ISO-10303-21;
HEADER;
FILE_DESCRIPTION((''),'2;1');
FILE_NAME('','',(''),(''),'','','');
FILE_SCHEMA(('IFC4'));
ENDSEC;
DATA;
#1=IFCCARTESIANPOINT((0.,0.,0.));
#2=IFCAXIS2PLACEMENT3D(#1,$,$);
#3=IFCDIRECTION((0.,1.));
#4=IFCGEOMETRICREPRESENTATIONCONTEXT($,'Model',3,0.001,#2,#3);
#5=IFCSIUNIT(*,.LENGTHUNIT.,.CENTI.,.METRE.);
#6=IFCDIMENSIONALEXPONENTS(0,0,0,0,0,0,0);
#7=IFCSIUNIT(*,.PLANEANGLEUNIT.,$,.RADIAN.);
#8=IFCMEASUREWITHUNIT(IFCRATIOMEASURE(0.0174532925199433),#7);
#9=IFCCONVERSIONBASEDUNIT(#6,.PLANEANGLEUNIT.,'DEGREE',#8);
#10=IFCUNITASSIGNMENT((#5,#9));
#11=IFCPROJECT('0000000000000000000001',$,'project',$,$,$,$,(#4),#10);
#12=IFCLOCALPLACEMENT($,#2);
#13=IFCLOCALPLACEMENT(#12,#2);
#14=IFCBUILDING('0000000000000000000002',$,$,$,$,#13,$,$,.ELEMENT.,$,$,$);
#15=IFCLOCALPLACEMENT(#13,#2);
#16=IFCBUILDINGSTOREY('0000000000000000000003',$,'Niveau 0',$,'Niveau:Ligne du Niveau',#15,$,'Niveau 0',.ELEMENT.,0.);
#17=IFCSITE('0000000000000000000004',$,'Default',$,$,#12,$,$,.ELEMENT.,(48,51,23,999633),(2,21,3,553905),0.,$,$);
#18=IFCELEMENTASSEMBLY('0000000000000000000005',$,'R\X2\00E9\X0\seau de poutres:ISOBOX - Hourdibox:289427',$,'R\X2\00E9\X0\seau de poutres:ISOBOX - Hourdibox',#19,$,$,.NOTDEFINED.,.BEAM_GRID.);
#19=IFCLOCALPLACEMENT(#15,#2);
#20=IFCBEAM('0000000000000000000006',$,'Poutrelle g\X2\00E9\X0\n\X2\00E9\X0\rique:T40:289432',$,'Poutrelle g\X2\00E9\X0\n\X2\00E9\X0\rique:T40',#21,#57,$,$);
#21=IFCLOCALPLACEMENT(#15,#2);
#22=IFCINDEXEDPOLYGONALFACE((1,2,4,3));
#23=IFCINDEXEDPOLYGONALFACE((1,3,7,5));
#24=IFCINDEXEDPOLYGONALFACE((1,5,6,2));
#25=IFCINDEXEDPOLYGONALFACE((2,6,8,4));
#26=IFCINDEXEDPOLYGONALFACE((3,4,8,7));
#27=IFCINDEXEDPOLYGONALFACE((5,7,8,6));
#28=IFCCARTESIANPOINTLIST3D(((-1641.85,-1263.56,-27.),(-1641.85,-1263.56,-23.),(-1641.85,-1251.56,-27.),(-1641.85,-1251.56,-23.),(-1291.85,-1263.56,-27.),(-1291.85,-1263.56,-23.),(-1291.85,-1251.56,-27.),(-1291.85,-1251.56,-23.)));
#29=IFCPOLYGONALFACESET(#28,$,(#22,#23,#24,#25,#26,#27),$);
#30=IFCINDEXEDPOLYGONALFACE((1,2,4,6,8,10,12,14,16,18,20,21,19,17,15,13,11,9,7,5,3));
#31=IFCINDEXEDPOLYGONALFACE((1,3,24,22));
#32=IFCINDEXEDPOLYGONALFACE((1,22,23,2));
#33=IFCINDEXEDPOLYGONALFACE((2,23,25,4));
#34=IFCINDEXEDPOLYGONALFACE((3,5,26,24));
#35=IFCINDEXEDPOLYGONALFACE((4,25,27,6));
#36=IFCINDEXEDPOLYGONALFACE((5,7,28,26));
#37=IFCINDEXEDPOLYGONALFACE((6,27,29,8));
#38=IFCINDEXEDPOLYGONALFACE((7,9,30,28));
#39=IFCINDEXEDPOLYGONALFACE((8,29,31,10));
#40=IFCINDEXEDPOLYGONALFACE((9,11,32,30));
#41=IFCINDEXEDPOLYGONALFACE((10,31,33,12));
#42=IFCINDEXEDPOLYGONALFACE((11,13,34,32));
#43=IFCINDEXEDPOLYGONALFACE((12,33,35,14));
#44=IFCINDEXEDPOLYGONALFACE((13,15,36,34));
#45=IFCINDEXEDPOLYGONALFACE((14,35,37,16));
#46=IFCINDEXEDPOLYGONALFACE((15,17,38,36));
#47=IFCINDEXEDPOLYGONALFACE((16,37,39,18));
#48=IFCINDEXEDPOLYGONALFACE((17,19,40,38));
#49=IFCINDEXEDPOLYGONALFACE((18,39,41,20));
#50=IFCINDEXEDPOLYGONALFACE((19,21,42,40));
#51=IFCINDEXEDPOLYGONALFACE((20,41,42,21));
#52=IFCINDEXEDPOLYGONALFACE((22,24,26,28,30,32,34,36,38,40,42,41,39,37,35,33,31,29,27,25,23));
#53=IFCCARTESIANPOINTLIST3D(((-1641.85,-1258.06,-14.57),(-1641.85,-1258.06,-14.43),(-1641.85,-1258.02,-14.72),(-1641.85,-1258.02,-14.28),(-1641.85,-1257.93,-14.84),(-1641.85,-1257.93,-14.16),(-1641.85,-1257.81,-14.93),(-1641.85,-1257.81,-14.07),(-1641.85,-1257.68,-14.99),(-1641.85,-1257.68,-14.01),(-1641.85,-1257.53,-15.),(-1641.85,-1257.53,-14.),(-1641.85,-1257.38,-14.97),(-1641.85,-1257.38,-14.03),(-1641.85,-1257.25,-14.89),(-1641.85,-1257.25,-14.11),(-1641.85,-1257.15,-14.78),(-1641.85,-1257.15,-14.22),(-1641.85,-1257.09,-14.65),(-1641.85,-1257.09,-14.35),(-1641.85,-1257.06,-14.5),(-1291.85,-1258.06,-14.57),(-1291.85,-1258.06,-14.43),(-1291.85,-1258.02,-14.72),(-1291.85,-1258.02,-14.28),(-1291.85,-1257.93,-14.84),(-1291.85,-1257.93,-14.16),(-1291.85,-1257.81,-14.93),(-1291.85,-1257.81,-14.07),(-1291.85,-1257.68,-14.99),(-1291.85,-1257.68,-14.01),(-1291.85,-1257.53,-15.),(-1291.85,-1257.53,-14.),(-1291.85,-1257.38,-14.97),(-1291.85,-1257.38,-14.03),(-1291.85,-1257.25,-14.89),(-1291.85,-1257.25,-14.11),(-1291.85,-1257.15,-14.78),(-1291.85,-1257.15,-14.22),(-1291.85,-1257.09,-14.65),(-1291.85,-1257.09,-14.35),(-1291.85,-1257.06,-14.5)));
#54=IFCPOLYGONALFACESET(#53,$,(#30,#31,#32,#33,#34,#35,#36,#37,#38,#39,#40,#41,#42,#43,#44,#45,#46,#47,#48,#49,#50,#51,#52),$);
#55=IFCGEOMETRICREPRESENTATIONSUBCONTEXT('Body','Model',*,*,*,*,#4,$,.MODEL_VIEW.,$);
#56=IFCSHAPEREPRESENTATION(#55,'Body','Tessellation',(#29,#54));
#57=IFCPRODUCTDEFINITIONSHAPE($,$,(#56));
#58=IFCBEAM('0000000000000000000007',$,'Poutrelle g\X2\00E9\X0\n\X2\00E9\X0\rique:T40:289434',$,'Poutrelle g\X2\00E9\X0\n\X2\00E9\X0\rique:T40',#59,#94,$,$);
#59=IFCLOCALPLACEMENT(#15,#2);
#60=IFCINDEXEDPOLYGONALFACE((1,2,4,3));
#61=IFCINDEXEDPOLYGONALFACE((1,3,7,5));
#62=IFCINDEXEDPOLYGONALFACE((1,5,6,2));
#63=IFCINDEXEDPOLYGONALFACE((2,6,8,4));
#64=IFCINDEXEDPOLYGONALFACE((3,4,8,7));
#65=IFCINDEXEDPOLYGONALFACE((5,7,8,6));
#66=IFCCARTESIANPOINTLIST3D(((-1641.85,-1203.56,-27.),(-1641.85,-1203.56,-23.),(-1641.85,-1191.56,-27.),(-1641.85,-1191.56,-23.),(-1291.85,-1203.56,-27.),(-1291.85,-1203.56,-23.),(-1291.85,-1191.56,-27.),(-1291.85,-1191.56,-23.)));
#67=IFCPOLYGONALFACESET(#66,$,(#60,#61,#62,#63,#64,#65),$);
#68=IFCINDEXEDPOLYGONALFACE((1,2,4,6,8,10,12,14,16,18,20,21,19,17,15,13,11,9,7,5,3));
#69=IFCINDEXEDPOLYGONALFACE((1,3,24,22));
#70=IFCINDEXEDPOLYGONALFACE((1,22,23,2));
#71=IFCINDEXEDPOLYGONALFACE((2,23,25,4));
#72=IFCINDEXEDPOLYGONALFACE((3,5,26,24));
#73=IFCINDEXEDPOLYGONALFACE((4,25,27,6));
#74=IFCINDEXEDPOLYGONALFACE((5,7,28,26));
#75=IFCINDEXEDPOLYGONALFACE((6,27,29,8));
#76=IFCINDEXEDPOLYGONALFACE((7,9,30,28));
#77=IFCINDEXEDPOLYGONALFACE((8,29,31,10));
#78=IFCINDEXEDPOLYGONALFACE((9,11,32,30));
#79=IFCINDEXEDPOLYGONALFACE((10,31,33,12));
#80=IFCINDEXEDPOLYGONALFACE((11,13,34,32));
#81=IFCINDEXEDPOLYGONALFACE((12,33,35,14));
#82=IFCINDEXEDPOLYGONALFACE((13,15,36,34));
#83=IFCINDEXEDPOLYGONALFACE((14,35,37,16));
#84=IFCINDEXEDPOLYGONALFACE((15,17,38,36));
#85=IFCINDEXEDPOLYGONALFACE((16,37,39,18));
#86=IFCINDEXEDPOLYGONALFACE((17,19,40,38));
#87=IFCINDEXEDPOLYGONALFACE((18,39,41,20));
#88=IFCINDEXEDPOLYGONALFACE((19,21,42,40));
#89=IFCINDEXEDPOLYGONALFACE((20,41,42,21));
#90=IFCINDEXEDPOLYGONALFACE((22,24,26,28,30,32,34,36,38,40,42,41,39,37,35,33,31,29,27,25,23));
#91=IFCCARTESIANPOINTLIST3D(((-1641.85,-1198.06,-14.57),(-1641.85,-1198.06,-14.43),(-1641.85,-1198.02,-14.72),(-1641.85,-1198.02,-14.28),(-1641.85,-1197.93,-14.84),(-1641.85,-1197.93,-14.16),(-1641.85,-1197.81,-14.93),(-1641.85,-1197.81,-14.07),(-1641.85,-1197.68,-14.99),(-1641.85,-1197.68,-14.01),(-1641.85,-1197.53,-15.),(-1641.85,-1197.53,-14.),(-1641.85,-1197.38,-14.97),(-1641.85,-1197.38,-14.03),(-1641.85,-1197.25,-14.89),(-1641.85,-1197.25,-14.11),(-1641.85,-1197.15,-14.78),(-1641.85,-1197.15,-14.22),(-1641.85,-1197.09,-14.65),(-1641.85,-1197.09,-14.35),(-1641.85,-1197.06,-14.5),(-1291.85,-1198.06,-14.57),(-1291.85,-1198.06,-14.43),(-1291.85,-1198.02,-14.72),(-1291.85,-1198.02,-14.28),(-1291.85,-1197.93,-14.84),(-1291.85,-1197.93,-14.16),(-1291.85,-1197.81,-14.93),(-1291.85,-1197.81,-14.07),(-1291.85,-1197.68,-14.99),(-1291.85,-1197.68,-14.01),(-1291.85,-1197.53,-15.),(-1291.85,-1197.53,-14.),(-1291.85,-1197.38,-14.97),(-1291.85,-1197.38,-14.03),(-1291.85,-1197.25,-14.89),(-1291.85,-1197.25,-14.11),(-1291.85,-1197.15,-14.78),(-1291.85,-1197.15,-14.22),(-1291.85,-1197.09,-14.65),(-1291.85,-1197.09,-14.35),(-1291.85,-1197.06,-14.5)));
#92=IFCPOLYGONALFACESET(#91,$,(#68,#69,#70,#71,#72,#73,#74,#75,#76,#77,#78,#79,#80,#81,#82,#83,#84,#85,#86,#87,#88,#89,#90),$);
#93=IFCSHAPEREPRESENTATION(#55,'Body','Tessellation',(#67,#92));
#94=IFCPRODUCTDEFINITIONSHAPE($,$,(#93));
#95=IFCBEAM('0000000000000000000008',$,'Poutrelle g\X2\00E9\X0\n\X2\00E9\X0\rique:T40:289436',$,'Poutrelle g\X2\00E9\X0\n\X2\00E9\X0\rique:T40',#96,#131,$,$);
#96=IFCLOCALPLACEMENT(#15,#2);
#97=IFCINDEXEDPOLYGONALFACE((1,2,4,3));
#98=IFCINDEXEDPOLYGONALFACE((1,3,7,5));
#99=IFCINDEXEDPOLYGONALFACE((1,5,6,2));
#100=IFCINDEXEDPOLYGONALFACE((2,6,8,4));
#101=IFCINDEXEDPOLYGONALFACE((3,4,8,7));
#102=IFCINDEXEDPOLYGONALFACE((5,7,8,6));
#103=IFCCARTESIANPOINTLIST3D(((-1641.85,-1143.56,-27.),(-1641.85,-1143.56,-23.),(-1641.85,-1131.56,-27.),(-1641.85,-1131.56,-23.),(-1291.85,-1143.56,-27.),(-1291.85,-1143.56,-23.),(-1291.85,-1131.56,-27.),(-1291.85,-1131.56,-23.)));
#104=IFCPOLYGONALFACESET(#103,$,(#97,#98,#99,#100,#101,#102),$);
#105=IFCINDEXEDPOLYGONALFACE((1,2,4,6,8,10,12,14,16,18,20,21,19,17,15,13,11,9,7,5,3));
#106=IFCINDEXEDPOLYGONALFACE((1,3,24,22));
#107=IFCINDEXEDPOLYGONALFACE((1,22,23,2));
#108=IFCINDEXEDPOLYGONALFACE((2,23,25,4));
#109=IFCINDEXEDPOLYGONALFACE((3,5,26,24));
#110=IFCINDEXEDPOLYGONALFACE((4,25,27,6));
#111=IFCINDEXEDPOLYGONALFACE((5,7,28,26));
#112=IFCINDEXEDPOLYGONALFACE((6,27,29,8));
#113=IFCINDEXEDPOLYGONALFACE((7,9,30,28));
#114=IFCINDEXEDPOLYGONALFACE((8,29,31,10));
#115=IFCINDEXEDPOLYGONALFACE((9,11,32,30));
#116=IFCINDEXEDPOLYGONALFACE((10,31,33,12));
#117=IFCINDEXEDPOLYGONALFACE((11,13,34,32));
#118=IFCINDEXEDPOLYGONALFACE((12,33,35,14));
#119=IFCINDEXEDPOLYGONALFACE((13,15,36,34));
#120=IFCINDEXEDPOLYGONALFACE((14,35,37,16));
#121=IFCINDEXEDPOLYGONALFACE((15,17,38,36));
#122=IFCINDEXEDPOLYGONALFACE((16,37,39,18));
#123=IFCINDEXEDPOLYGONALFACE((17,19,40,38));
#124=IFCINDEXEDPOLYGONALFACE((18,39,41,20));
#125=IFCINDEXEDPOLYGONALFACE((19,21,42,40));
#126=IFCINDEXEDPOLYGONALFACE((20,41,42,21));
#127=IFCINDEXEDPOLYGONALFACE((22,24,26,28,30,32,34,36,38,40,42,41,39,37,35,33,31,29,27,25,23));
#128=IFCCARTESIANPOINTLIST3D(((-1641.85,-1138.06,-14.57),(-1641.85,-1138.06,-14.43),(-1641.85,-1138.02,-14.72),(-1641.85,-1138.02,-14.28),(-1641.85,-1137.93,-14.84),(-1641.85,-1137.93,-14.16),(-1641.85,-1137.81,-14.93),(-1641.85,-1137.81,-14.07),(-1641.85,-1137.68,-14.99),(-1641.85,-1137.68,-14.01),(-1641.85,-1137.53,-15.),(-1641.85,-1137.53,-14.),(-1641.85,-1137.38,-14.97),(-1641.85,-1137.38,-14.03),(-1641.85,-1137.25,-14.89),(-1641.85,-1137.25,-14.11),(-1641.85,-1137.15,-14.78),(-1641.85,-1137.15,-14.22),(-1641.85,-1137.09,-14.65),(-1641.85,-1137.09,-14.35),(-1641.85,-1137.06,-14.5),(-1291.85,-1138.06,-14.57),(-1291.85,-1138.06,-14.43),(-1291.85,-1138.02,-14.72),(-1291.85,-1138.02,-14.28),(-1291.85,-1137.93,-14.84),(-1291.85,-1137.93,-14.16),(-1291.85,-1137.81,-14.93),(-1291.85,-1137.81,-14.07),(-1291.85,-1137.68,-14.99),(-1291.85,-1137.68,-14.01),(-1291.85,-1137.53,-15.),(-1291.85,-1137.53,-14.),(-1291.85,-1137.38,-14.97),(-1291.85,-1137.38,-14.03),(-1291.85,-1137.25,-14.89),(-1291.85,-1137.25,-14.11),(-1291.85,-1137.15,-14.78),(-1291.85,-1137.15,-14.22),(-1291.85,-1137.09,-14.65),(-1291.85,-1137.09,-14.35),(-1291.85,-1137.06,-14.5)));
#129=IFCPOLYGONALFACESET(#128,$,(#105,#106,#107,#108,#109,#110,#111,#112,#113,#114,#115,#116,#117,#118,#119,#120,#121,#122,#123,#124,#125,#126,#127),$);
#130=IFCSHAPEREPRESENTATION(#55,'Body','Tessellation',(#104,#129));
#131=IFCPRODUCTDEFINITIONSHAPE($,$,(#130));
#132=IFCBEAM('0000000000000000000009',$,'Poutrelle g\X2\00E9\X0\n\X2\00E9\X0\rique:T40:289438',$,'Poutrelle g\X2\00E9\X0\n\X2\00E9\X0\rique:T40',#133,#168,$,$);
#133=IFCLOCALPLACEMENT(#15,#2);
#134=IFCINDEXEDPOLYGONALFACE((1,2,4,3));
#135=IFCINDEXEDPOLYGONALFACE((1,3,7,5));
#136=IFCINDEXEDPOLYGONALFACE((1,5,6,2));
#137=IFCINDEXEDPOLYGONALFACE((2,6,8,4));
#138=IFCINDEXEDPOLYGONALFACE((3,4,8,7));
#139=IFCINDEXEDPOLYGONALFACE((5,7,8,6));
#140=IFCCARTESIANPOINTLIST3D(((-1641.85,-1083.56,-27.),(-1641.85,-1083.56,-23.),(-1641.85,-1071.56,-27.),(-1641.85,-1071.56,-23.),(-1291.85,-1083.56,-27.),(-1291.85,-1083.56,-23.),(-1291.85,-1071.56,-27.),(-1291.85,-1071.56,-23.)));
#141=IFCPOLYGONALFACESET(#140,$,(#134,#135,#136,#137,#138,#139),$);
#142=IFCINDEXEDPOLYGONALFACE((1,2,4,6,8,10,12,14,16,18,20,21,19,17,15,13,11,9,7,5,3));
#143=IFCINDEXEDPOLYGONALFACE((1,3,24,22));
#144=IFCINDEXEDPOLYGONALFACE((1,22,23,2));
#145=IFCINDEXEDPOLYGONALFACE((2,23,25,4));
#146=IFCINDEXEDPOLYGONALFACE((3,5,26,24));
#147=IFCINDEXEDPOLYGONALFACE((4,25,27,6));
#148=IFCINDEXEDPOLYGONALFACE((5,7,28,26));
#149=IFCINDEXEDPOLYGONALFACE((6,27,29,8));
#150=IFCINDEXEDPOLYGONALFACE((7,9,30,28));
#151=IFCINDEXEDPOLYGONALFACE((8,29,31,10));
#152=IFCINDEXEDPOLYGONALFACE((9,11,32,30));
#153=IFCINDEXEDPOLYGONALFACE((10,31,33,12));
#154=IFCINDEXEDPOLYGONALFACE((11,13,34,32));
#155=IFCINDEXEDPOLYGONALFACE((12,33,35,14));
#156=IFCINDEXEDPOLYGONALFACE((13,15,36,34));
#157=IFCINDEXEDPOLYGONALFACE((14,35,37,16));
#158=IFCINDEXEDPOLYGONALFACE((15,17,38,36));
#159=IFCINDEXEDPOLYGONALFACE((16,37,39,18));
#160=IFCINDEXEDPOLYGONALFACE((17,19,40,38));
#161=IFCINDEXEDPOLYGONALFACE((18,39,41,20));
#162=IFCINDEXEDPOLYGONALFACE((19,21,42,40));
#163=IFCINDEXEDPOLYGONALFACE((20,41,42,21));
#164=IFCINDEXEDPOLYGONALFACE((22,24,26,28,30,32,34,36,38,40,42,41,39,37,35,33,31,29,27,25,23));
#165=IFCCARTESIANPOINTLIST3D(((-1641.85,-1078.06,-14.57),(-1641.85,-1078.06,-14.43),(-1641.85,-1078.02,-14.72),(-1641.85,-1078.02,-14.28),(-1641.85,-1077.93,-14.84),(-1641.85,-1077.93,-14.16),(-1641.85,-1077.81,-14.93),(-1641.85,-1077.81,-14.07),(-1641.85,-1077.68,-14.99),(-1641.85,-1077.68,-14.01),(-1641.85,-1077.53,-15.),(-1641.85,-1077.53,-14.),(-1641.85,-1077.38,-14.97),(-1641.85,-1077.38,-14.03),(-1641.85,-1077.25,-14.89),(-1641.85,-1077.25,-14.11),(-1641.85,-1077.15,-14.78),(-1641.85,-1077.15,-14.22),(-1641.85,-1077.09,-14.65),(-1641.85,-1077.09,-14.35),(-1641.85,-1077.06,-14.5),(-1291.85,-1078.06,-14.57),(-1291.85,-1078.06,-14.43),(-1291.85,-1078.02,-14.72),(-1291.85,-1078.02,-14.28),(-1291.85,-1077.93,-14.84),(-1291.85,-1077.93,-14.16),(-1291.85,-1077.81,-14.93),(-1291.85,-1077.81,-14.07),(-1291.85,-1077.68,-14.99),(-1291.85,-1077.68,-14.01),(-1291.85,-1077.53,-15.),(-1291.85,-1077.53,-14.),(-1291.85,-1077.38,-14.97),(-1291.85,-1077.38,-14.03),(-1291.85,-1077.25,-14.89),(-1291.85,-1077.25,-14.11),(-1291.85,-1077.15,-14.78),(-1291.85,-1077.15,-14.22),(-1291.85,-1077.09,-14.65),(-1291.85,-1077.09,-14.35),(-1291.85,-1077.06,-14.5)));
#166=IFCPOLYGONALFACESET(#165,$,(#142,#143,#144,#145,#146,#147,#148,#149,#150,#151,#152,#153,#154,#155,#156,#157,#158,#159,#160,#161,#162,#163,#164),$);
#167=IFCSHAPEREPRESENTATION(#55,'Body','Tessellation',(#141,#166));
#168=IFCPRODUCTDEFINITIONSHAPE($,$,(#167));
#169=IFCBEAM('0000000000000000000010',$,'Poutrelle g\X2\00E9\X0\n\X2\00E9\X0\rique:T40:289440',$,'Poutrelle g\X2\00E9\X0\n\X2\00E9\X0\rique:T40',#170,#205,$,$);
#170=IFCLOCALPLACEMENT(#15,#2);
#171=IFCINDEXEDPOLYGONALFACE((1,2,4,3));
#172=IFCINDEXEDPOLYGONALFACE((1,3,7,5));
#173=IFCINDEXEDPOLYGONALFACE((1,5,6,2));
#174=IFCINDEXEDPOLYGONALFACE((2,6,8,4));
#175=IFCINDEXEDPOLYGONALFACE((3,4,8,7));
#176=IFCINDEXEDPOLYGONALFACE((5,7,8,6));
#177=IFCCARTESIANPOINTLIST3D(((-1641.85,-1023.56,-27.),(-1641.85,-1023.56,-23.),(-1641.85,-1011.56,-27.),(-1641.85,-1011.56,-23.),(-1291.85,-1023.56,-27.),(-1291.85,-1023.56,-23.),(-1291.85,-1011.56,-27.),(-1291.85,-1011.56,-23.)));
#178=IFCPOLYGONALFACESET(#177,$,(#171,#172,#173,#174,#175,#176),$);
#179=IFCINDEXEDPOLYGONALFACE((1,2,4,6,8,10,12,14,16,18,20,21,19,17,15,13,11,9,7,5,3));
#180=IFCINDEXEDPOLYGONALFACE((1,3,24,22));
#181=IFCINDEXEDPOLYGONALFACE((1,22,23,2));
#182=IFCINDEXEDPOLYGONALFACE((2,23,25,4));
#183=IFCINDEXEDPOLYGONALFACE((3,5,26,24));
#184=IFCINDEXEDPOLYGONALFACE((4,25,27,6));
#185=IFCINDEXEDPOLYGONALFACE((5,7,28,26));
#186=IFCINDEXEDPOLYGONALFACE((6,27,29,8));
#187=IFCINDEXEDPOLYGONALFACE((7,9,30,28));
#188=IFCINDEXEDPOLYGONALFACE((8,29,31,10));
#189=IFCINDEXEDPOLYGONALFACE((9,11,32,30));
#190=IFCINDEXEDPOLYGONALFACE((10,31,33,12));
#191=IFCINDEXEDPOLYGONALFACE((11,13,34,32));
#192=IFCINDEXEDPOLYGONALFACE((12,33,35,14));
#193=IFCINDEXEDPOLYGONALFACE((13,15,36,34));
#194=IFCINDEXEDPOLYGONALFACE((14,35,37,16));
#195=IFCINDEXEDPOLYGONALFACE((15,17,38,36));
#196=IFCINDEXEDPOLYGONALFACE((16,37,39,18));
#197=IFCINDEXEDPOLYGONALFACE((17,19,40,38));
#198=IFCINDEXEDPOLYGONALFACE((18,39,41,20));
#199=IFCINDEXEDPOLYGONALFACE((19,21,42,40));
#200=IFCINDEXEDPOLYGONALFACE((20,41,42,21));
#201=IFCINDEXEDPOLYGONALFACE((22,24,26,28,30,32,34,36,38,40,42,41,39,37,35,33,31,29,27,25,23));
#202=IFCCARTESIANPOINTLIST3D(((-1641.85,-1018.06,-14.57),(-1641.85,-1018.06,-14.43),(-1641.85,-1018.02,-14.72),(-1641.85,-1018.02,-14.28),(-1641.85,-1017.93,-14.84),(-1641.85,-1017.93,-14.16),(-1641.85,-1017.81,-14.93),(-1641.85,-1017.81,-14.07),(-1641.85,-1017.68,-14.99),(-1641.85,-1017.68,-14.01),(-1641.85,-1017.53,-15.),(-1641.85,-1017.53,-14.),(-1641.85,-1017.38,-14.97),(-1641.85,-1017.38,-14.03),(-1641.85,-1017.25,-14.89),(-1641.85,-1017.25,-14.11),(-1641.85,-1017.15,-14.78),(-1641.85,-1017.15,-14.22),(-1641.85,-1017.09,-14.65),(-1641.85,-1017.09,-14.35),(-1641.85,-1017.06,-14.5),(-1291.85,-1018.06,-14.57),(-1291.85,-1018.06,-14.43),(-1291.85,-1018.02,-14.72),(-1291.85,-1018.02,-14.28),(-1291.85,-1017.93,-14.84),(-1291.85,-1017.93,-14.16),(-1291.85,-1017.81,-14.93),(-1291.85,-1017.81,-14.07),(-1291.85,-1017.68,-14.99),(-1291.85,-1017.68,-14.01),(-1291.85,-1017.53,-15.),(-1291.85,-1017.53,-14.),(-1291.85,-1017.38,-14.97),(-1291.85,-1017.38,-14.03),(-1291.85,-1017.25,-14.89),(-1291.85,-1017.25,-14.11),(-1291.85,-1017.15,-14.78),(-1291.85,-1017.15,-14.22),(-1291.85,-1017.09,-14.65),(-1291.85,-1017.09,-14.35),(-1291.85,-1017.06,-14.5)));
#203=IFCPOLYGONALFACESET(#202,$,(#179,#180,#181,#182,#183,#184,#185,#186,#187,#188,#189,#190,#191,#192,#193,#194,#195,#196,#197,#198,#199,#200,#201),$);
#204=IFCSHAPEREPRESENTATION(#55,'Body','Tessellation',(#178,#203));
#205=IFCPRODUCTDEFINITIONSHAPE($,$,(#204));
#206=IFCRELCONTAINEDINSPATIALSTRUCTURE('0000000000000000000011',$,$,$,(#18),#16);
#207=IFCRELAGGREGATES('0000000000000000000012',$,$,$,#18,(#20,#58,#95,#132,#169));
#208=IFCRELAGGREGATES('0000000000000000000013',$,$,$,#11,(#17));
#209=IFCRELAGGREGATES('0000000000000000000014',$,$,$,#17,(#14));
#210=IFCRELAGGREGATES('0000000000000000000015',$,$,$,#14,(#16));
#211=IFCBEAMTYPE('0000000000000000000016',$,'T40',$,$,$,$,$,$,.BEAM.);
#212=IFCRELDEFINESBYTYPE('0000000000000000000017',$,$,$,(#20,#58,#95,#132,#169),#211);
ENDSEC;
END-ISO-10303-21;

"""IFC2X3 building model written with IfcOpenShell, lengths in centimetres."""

from ifc_helpers import new_model, entity, si_unit, converted_unit, direction, frame, frame_2d, origin, origin_2d_with_axis, place, context, subcontext, project, spatial, rectangle, circle, extrude, source, transform, mapped, type_object, type_shapes, element, aggregate, save


model = new_model("IFC2X3")

# Units and contexts
model_context = context("Model", 3, precision=0.001, world=origin(), true_north=direction((0.0, 1.0)))
body_context = subcontext(model_context, "Body", "Model", "MODEL_VIEW")
ifc_project = project(units=[si_unit("LENGTHUNIT", "METRE", prefix="CENTI"), converted_unit("PLANEANGLEUNIT", "DEGREE", entity("IfcRatioMeasure", 0.0174532925199433), si_unit("PLANEANGLEUNIT", "RADIAN"), dimensions=[0, 0, 0, 0, 0, 0, 0])], contexts=[model_context])

# Site, building, storey
site_placement = place(None, origin())
site = spatial("IfcSite", under=ifc_project, at=site_placement, Name="Default", CompositionType="ELEMENT", RefLatitude=(48, 51, 23, 999633), RefLongitude=(2, 21, 3, 553905), RefElevation=0.0)
building_placement = place(site_placement, origin())
building = spatial("IfcBuilding", under=site, at=building_placement, CompositionType="ELEMENT")
storey_placement = place(building_placement, origin())
storey = spatial("IfcBuildingStorey", under=building, at=storey_placement, Name="Niveau 0", ObjectType="Niveau:Ligne du Niveau", LongName="Niveau 0", CompositionType="ELEMENT", Elevation=0.0)

# Element assembly, beams
assembly_placement = place(storey_placement, origin())
assembly = element("IfcElementAssembly", 1, at=assembly_placement, inside=storey, Name="Réseau de poutres:ISOBOX - Hourdibox:289427", ObjectType="Réseau de poutres:ISOBOX - Hourdibox", AssemblyPlace="NOTDEFINED", PredefinedType="BEAM_GRID")
beam_type = type_object("IfcBeamType", Name="T40", PredefinedType="BEAM")
shared_shape_1 = source(origin(), body_context, "Body", "SweptSolid", [
    extrude(rectangle(XDim=4.0, YDim=12.0, at=origin_2d_with_axis()), frame((175.0, 0.0, -4.5), z_axis=(-1.0, 0.0, 0.0), x_axis=(0.0, 0.0, -1.0)), (0.0, 0.0, 1.0), 350.0),
    extrude(circle(Radius=0.5, at=frame_2d((0.0, 0.0), x_axis=(1.0, 0.0))), frame((175.0, 0.0, 6.0), z_axis=(-1.0, 0.0, 0.0), x_axis=(0.0, -1.0, 0.0)), (0.0, 0.0, 1.0), 350.0),
])
type_shapes(beam_type, [shared_shape_1])
beam_1_placement = place(assembly_placement, frame((-1466.85, -1257.56, -20.5), z_axis=(0.0, 0.0, 1.0), x_axis=(-1.0, 0.0, 0.0)))
beam_1 = element("IfcBeam", 2, at=beam_1_placement, type_object=beam_type, Name="Poutrelle générique:T40:289432", ObjectType="Poutrelle générique:T40", context=body_context, shape_type="MappedRepresentation", body=[
    mapped(shared_shape_1, transform((0.0, 0.0, 0.0), scale=1.0)),
])
beam_2_placement = place(assembly_placement, frame((-1466.85, -1197.56, -20.5), z_axis=(0.0, 0.0, 1.0), x_axis=(-1.0, 0.0, 0.0)))
beam_2 = element("IfcBeam", 3, at=beam_2_placement, type_object=beam_type, Name="Poutrelle générique:T40:289434", ObjectType="Poutrelle générique:T40", context=body_context, shape_type="MappedRepresentation", body=[
    mapped(shared_shape_1, transform((0.0, 0.0, 0.0), scale=1.0)),
])
beam_3_placement = place(assembly_placement, frame((-1466.85, -1137.56, -20.5), z_axis=(0.0, 0.0, 1.0), x_axis=(-1.0, 0.0, 0.0)))
beam_3 = element("IfcBeam", 4, at=beam_3_placement, type_object=beam_type, Name="Poutrelle générique:T40:289436", ObjectType="Poutrelle générique:T40", context=body_context, shape_type="MappedRepresentation", body=[
    mapped(shared_shape_1, transform((0.0, 0.0, 0.0), scale=1.0)),
])
beam_4_placement = place(assembly_placement, frame((-1466.85, -1077.56, -20.5), z_axis=(0.0, 0.0, 1.0), x_axis=(-1.0, 0.0, 0.0)))
beam_4 = element("IfcBeam", 5, at=beam_4_placement, type_object=beam_type, Name="Poutrelle générique:T40:289438", ObjectType="Poutrelle générique:T40", context=body_context, shape_type="MappedRepresentation", body=[
    mapped(shared_shape_1, transform((0.0, 0.0, 0.0), scale=1.0)),
])
beam_5_placement = place(assembly_placement, frame((-1466.85, -1017.56, -20.5), z_axis=(0.0, 0.0, 1.0), x_axis=(-1.0, 0.0, 0.0)))
beam_5 = element("IfcBeam", 6, at=beam_5_placement, type_object=beam_type, Name="Poutrelle générique:T40:289440", ObjectType="Poutrelle générique:T40", context=body_context, shape_type="MappedRepresentation", body=[
    mapped(shared_shape_1, transform((0.0, 0.0, 0.0), scale=1.0)),
])
aggregate(assembly, [beam_1, beam_2, beam_3, beam_4, beam_5])

save(model, "model.ifc")
